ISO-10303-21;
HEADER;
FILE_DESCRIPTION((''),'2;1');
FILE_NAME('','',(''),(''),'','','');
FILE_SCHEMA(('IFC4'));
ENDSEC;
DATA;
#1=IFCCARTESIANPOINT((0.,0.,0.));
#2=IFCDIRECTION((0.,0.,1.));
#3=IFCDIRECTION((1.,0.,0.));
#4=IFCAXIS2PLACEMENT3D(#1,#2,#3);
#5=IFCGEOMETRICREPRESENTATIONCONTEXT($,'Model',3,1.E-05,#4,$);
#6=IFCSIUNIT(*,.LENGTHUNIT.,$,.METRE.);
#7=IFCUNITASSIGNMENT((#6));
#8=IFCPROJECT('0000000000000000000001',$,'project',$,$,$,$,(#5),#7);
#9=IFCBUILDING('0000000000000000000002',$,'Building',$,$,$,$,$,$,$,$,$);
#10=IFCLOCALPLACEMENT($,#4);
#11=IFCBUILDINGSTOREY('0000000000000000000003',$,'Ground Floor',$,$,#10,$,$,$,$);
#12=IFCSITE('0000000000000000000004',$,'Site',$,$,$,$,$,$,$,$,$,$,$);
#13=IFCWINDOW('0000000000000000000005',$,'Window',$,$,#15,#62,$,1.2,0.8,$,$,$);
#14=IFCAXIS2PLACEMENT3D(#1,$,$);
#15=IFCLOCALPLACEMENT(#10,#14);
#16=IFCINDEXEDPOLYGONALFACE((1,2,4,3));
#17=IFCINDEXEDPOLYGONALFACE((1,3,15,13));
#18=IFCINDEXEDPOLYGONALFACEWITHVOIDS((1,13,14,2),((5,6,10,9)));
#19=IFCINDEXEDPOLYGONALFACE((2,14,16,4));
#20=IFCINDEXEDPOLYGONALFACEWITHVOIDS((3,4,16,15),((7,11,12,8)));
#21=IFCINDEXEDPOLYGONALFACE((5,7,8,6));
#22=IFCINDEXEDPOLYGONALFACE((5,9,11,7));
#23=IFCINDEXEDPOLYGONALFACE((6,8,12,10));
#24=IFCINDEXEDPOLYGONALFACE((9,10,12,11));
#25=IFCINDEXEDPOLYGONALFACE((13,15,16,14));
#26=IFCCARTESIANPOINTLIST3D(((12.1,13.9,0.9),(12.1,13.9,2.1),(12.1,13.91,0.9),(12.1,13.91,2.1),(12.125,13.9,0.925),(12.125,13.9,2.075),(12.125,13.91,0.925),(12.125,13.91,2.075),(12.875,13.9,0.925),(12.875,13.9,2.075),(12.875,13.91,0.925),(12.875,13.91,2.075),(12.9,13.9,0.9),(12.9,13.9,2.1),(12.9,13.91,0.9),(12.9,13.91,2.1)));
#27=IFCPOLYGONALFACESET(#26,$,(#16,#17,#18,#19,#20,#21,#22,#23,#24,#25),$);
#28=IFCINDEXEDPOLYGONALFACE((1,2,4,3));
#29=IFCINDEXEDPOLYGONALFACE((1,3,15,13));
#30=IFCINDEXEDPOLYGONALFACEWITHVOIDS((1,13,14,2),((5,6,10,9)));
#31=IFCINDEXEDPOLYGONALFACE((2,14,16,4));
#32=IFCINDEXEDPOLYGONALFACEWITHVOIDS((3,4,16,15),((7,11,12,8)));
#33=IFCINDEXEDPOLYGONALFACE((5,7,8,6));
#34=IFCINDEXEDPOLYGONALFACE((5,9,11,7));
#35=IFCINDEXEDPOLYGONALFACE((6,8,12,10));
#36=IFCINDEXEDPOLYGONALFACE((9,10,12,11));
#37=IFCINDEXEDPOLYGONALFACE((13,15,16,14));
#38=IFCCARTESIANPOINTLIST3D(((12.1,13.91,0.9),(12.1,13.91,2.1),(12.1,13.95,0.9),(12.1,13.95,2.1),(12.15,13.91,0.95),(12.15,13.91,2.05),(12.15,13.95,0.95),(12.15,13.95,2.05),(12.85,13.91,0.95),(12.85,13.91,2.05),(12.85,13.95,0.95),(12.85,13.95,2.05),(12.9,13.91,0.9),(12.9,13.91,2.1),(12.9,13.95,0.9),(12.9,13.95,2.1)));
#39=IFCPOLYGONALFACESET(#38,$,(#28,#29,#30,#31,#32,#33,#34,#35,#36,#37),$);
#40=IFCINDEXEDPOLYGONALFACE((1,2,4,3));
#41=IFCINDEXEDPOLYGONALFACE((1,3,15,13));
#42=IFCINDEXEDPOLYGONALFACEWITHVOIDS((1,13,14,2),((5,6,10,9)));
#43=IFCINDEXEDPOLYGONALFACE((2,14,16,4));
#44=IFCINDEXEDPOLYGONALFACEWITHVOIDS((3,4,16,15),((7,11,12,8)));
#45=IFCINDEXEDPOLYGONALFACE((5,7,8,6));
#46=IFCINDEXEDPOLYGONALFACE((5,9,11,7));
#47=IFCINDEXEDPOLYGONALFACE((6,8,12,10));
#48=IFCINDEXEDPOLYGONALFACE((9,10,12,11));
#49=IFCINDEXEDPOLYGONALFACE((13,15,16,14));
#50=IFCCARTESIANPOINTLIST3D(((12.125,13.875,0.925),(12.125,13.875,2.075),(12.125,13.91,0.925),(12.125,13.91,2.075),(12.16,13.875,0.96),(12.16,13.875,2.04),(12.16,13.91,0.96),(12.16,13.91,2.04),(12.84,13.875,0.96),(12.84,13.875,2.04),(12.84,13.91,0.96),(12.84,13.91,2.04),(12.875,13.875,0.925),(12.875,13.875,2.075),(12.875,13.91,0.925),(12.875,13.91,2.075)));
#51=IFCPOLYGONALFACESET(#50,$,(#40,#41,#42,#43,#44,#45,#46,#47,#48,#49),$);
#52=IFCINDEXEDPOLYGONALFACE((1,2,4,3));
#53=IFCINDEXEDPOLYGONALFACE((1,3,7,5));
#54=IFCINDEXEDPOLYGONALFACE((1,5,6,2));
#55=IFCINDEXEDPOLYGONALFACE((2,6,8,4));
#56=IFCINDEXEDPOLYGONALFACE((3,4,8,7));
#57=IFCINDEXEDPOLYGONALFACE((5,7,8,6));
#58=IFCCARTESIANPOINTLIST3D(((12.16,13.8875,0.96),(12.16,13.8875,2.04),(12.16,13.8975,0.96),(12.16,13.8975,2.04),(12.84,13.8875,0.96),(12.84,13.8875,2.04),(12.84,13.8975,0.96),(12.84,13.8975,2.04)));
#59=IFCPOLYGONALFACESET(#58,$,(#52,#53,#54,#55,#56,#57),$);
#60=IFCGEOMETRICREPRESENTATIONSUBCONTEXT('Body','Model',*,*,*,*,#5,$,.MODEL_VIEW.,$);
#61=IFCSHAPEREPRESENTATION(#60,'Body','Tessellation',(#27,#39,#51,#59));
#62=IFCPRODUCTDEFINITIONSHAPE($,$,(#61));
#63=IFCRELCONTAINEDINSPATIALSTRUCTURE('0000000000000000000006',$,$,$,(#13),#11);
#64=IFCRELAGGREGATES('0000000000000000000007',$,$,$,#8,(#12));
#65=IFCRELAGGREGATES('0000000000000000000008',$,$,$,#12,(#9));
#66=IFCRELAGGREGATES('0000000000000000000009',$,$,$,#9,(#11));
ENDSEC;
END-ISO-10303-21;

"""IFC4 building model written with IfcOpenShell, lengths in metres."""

from ifc_helpers import new_model, si_unit, frame, origin_with_axes, place, context, subcontext, project, spatial, line, indexed_curve, outline, extrude, element, save


model = new_model("IFC4")

# Units and contexts
model_context = context("Model", 3, precision=1e-05, world=origin_with_axes())
body_context = subcontext(model_context, "Body", "Model", "MODEL_VIEW")
ifc_project = project(units=[si_unit("LENGTHUNIT", "METRE")], contexts=[model_context])

# Site, building, storey
site = spatial("IfcSite", under=ifc_project, Name="Site")
building = spatial("IfcBuilding", under=site, Name="Building")
storey_placement = place(None, origin_with_axes())
storey = spatial("IfcBuildingStorey", under=building, at=storey_placement, Name="Ground Floor")

# Window
for number, where, z_axis, x_axis, name in (
    (1, (12.9, 14.0, 0.9), (0.0, 0.0, 1.0), (-1.0, 0.0, 0.0), "Window"),
):
    element("IfcWindow", number, at=place(storey_placement, frame(where, z_axis=z_axis, x_axis=x_axis)), inside=storey, Name=name, OverallHeight=1.2, OverallWidth=0.8, context=body_context, shape_type="SweptSolid", body=[
        extrude(outline(indexed_curve([(0.0, 0.0), (0.8, 0.0), (0.8, 1.2), (0.0, 1.2)], segments=[line(1, 2, 3, 4, 1)]), holes=[indexed_curve([(0.025, 0.025), (0.775, 0.025), (0.775, 1.175), (0.025, 1.175)], segments=[line(1, 2, 3, 4, 1)])]), frame((0.0, 0.09, 0.0), z_axis=(0.0, -1.0, 0.0), x_axis=(1.0, 0.0, 0.0)), (0.0, 0.0, -1.0), 0.01),
        extrude(outline(indexed_curve([(0.0, 0.0), (0.8, 0.0), (0.8, 1.2), (0.0, 1.2)], segments=[line(1, 2, 3, 4, 1)]), holes=[indexed_curve([(0.05, 0.05), (0.75, 0.05), (0.75, 1.15), (0.05, 1.15)], segments=[line(1, 2, 3, 4, 1)])]), frame((0.0, 0.05, 0.0), z_axis=(0.0, -1.0, 0.0), x_axis=(1.0, 0.0, 0.0)), (0.0, 0.0, -1.0), 0.04),
        extrude(outline(indexed_curve([(0.0, 0.0), (0.75, 0.0), (0.75, 1.15), (0.0, 1.15)], segments=[line(1, 2, 3, 4, 1)]), holes=[indexed_curve([(0.035, 0.035), (0.715, 0.035), (0.715, 1.115), (0.035, 1.115)], segments=[line(1, 2, 3, 4, 1)])]), frame((0.025, 0.09, 0.025), z_axis=(0.0, -1.0, 0.0), x_axis=(1.0, 0.0, 0.0)), (0.0, 0.0, -1.0), 0.035),
        extrude(outline(indexed_curve([(0.035, 0.035), (0.715, 0.035), (0.715, 1.115), (0.035, 1.115)], segments=[line(1, 2, 3, 4, 1)])), frame((0.025, 0.1025, 0.025), z_axis=(0.0, -1.0, 0.0), x_axis=(1.0, 0.0, 0.0)), (0.0, 0.0, -1.0), 0.01),
    ])

save(model, "model.ifc")
